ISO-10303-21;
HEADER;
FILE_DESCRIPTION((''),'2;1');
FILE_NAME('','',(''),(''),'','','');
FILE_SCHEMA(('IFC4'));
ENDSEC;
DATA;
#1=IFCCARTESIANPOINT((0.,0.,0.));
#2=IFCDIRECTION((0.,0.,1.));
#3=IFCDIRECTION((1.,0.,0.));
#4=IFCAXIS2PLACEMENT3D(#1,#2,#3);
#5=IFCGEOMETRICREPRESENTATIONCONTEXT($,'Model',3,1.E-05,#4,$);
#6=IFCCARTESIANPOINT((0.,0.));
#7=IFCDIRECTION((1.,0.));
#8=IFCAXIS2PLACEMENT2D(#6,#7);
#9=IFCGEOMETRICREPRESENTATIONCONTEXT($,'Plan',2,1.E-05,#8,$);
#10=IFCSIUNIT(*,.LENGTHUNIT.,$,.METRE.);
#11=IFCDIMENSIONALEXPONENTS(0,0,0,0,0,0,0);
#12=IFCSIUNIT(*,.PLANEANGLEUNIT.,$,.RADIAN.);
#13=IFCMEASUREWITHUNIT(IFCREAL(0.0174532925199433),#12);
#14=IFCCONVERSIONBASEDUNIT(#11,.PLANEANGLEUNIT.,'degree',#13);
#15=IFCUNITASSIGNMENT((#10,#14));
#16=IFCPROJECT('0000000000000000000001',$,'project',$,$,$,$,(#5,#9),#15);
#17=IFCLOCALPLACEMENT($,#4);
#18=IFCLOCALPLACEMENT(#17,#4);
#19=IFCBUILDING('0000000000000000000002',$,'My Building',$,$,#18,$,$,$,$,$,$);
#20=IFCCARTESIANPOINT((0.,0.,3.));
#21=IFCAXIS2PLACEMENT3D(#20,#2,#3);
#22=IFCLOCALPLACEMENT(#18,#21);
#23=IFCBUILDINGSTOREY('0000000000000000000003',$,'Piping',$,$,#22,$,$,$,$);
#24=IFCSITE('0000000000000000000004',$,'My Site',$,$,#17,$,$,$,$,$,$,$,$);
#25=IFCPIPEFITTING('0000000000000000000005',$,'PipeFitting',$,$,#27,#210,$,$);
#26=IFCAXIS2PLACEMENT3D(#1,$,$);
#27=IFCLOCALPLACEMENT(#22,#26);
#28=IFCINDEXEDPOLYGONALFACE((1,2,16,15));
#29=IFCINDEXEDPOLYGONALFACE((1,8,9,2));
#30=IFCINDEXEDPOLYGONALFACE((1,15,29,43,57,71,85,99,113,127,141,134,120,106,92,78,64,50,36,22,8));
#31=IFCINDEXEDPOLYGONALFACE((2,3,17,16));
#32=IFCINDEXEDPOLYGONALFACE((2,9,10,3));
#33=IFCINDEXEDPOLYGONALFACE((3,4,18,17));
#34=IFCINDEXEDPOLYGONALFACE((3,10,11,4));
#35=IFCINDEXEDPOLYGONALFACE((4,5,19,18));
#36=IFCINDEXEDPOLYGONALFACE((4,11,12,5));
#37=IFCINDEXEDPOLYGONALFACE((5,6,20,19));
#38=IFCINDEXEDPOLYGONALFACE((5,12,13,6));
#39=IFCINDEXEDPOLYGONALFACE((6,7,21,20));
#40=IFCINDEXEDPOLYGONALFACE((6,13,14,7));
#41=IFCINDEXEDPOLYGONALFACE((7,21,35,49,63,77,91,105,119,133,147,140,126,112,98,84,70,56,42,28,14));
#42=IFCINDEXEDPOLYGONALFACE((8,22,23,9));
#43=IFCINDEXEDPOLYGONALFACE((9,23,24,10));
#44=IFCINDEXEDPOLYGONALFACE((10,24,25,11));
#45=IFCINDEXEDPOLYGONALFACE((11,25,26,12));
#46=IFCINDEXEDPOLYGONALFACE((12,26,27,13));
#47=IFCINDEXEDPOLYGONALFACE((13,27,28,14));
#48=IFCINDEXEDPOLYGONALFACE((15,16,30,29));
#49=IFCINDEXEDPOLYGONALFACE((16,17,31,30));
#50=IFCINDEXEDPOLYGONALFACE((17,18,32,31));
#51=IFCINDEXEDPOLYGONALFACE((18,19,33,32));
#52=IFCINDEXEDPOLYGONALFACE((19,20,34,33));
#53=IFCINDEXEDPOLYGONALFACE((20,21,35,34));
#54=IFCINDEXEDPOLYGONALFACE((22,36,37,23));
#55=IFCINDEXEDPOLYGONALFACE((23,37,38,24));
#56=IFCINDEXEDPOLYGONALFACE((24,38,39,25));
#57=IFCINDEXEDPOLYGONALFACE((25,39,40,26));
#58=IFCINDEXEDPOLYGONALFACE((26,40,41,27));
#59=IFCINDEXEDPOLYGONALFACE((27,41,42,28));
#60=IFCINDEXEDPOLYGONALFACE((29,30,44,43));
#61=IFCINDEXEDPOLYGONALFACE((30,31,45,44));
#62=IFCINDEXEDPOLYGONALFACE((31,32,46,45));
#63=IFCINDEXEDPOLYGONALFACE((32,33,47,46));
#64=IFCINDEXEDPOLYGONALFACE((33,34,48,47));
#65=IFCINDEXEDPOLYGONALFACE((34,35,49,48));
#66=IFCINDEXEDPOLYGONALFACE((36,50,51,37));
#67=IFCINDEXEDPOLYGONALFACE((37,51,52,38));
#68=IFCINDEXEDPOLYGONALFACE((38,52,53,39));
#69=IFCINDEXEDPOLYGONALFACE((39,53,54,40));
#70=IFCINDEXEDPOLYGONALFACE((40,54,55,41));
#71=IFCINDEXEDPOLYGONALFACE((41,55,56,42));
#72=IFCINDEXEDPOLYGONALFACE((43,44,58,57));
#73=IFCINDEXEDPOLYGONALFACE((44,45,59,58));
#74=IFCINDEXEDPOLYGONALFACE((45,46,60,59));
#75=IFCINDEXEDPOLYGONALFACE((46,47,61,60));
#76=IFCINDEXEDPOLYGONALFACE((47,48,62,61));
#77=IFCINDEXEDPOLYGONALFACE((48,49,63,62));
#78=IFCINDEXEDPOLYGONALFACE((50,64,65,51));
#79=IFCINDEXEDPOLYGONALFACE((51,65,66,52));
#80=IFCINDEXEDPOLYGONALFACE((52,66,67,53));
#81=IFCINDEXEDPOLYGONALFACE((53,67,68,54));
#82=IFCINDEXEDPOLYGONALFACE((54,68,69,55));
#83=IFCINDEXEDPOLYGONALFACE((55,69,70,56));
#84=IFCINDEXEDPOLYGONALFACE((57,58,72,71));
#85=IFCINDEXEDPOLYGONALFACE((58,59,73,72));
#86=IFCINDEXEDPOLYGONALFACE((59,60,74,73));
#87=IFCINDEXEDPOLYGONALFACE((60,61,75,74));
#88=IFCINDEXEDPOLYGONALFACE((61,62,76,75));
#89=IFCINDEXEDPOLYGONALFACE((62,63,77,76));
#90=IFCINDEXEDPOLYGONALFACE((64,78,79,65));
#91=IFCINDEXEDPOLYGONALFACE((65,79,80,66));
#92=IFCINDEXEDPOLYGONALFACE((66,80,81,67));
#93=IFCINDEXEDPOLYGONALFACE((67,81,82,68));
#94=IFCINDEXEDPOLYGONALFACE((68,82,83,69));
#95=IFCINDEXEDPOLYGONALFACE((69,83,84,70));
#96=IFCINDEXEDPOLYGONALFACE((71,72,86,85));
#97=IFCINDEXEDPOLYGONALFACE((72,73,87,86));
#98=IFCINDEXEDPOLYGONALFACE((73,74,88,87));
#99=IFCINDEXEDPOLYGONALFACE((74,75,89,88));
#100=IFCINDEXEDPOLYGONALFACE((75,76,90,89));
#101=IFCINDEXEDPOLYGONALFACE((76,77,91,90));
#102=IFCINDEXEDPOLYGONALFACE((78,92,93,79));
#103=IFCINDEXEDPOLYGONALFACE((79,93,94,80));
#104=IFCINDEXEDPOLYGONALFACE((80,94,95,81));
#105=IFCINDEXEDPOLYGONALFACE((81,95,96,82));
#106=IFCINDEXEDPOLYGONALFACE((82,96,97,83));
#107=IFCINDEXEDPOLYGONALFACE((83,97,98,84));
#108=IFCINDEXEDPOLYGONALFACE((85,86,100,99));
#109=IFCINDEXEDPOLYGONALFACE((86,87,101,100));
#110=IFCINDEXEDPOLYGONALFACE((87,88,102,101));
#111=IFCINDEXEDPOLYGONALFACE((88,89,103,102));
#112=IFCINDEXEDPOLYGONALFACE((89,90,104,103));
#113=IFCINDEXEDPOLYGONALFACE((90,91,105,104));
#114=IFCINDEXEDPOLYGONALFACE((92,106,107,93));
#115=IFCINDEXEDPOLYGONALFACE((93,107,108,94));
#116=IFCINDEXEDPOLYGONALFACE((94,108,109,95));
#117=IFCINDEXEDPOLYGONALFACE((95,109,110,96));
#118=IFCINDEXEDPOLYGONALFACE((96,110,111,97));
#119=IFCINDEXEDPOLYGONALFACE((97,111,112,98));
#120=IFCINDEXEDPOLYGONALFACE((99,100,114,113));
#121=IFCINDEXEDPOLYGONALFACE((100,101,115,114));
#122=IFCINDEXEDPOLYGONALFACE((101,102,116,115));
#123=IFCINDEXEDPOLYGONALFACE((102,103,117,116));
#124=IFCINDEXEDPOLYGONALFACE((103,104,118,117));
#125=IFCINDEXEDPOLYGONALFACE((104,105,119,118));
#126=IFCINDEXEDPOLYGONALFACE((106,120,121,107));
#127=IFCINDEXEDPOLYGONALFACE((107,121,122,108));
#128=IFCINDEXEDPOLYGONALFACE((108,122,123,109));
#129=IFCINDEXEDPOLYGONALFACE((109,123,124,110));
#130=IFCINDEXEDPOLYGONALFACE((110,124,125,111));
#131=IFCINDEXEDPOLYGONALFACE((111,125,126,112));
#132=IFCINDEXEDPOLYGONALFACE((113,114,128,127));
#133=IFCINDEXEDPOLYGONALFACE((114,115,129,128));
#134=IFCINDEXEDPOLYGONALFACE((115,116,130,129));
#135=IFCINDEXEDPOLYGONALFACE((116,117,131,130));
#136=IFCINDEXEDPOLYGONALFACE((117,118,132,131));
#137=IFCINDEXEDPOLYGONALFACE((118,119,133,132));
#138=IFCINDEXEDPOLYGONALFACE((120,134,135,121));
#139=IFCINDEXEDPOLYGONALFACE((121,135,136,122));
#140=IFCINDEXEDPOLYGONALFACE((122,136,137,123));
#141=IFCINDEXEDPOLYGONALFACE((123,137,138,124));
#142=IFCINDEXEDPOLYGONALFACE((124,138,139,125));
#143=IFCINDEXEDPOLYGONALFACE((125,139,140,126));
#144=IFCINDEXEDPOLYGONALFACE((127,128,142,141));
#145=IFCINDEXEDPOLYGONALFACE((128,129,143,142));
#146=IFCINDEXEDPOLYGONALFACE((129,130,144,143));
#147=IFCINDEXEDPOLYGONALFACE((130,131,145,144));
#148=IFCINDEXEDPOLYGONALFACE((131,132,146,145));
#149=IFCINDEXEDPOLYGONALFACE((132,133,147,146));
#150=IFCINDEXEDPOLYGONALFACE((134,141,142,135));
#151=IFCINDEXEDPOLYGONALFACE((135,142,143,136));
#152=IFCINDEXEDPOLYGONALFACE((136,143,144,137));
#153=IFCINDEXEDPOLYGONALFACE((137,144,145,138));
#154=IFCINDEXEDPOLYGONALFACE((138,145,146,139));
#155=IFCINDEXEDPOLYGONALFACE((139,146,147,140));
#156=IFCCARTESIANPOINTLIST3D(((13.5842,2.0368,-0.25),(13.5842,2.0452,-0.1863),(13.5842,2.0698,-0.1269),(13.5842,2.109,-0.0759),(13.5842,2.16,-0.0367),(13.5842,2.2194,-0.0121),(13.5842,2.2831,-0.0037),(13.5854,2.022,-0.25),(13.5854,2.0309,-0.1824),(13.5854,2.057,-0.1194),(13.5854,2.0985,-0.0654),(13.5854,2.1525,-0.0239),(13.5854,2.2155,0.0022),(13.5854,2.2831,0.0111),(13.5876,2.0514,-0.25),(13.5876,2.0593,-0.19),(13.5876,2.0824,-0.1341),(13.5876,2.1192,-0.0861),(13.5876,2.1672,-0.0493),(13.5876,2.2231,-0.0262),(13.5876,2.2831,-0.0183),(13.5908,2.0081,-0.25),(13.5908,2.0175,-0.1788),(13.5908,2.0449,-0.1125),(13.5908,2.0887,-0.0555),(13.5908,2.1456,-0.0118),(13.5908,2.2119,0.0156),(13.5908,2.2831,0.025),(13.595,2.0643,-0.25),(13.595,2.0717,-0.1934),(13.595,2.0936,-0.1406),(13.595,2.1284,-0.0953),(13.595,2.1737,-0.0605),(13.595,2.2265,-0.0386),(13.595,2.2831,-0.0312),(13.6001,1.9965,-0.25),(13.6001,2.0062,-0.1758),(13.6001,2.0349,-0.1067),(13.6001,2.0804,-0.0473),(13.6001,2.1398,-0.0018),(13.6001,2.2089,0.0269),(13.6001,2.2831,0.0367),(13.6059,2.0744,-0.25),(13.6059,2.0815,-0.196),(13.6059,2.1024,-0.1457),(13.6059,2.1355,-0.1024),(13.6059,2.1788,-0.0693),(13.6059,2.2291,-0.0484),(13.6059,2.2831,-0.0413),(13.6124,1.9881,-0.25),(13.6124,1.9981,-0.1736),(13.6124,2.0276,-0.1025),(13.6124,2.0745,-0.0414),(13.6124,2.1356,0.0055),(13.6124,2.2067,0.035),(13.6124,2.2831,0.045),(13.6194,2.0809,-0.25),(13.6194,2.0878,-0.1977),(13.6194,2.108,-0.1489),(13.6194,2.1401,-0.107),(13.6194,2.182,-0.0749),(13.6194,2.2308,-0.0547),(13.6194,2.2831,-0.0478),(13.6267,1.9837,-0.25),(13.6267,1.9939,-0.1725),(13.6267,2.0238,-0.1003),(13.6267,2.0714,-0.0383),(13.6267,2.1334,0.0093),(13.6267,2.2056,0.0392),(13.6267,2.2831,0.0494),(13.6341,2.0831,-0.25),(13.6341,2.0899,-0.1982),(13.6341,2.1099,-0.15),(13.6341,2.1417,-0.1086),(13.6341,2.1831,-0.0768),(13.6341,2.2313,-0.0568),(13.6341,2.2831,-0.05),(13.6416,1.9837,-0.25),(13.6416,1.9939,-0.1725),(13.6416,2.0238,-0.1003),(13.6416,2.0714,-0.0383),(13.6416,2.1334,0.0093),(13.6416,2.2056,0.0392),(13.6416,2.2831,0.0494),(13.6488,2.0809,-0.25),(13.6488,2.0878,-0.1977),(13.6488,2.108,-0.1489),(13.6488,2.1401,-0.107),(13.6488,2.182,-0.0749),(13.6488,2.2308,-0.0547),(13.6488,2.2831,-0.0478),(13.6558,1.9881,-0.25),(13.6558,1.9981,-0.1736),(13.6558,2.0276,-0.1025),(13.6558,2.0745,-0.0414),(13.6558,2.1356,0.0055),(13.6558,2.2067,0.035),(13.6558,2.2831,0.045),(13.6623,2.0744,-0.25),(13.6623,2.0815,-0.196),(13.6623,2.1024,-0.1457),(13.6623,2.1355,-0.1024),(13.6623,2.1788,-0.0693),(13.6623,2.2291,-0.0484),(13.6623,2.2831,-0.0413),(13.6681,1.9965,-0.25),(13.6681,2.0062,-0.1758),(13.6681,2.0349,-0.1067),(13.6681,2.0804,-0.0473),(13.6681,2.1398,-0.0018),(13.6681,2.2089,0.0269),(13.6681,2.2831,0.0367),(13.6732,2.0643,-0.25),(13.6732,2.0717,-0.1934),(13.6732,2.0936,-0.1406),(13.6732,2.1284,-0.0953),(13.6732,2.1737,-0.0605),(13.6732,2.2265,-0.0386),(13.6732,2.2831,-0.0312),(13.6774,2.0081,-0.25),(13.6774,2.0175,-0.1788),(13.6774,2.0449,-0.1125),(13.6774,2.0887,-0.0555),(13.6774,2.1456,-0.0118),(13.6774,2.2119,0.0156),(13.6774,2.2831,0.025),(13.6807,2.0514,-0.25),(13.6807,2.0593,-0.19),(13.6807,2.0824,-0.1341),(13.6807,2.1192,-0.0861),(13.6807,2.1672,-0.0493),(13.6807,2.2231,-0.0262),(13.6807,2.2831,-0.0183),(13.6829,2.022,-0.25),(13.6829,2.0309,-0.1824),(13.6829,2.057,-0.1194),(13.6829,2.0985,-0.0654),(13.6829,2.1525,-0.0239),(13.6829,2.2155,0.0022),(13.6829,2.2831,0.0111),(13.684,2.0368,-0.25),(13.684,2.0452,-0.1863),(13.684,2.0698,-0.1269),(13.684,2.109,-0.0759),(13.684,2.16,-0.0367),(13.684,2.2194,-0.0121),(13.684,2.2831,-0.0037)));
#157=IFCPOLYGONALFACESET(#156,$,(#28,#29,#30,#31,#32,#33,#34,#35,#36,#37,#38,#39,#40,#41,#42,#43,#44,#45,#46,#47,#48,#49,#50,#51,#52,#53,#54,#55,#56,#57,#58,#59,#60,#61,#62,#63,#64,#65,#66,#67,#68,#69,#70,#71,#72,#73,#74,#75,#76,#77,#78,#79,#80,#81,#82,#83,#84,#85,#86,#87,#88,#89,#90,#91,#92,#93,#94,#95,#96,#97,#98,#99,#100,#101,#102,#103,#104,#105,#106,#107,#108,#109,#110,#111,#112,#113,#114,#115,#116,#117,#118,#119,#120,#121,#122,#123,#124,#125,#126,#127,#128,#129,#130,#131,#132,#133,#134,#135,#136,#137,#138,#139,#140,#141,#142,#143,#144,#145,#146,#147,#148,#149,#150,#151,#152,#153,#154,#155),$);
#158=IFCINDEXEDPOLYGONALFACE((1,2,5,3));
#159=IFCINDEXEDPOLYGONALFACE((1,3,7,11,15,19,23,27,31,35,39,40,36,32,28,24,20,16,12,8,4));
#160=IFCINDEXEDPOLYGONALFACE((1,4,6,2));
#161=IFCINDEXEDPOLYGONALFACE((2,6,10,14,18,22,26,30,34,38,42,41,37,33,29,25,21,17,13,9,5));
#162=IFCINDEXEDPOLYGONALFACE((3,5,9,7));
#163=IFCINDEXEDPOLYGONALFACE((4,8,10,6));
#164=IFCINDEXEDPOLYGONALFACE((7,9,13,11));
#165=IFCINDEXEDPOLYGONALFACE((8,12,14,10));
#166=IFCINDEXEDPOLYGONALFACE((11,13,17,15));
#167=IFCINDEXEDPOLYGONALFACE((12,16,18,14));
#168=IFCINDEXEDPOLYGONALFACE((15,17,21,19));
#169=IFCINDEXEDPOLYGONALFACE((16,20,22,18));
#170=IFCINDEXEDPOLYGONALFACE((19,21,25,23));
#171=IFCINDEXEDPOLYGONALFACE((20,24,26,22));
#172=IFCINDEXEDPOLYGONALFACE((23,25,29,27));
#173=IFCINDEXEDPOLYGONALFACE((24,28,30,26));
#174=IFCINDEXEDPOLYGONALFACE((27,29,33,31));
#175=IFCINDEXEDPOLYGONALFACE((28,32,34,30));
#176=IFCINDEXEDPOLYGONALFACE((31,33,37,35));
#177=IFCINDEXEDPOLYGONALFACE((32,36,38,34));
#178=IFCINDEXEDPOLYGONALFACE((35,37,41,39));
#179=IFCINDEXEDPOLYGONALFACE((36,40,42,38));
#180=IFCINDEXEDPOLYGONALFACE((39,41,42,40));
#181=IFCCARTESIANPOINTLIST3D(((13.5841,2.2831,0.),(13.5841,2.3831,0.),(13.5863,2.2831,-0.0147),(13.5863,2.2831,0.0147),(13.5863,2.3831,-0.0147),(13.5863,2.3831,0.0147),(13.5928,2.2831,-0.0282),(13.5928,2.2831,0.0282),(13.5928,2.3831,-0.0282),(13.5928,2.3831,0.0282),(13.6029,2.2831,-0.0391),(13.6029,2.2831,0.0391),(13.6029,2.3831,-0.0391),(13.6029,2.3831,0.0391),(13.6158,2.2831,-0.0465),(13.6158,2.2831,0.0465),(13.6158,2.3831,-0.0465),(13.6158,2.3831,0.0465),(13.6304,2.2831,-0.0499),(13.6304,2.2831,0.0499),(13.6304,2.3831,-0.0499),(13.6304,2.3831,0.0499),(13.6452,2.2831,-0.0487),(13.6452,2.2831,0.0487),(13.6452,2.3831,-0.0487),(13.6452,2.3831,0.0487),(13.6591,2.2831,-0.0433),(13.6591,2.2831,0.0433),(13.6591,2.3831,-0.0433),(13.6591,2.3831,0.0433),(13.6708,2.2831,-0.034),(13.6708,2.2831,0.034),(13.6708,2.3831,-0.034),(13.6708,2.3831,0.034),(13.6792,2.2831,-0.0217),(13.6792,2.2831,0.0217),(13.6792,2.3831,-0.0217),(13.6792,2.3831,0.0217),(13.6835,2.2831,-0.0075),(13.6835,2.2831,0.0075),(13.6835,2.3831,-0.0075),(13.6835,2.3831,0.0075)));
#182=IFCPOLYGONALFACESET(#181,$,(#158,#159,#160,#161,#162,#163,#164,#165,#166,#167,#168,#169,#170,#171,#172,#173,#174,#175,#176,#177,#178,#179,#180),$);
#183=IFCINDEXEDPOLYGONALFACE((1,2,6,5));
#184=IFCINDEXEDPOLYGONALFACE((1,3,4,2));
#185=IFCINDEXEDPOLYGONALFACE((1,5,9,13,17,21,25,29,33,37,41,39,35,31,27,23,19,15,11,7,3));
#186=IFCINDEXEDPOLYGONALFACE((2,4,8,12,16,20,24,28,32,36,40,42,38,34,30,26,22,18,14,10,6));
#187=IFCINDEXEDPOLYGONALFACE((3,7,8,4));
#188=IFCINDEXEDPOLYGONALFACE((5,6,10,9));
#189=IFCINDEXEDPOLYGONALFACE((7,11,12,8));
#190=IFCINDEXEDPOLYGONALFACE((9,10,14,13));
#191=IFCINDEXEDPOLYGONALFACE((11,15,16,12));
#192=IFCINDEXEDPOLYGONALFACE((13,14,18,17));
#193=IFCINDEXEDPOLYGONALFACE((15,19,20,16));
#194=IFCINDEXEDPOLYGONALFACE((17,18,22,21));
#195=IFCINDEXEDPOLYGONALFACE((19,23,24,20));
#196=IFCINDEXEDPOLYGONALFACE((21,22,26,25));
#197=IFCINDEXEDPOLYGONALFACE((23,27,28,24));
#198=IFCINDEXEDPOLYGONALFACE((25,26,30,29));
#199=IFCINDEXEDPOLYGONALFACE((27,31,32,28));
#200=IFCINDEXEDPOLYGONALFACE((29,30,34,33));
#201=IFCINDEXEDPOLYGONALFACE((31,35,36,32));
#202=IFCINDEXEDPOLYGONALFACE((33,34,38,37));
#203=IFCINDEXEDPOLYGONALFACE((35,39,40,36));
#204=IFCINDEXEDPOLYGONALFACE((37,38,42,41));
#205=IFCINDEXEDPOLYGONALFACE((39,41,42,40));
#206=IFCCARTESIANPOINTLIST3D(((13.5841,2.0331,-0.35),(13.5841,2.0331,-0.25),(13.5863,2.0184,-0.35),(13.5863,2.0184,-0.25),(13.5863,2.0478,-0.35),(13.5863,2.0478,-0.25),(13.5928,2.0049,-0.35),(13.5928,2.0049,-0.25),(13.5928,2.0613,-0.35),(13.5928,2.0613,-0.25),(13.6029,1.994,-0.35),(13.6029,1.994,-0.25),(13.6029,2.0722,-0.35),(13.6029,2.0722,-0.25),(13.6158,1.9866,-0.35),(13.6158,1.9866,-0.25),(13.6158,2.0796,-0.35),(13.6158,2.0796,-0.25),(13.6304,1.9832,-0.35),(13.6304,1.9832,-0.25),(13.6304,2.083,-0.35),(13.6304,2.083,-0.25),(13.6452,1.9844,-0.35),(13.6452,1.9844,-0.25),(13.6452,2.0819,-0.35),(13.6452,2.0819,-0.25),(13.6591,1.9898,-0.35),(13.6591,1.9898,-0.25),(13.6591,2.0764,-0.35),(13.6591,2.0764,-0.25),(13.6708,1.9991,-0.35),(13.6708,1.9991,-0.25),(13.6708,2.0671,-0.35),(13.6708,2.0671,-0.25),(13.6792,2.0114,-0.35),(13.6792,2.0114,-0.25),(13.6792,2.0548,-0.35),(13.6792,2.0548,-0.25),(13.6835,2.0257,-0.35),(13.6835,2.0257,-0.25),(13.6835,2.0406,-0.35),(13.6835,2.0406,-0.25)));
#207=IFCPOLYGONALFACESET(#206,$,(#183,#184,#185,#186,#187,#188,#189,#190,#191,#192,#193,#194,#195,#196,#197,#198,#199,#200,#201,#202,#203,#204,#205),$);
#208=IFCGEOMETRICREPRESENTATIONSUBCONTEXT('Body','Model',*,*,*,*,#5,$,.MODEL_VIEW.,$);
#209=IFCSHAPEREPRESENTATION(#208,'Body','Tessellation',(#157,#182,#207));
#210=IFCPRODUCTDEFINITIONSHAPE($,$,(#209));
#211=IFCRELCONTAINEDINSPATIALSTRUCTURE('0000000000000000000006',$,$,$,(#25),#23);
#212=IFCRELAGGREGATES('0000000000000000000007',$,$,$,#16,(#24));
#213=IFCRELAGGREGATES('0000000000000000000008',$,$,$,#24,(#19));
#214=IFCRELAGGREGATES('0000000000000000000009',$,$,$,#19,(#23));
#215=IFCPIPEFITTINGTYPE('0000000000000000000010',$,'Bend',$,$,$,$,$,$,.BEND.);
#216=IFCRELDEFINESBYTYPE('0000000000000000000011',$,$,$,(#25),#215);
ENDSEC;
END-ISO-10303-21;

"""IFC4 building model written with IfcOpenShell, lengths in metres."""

from ifc_helpers import new_model, entity, si_unit, converted_unit, frame, origin_with_axes, origin_2d_with_axis, place, context, subcontext, project, spatial, circle, extrude, source, transform, mapped, type_object, type_shapes, element, save


model = new_model("IFC4")

# Units and contexts
model_context = context("Model", 3, precision=1e-05, world=origin_with_axes())
plan_context = context("Plan", 2, precision=1e-05, world=origin_2d_with_axis())
body_context = subcontext(model_context, "Body", "Model", "MODEL_VIEW")
ifc_project = project(units=[si_unit("LENGTHUNIT", "METRE"), converted_unit("PLANEANGLEUNIT", "degree", entity("IfcReal", 0.0174532925199433), si_unit("PLANEANGLEUNIT", "RADIAN"), dimensions=[0, 0, 0, 0, 0, 0, 0])], contexts=[model_context, plan_context])

# Site, building, storey
site_placement = place(None, origin_with_axes())
site = spatial("IfcSite", under=ifc_project, at=site_placement, Name="My Site")
building_placement = place(site_placement, origin_with_axes())
building = spatial("IfcBuilding", under=site, at=building_placement, Name="My Building")
storey_placement = place(building_placement, frame((0.0, 0.0, 3.0), z_axis=(0.0, 0.0, 1.0), x_axis=(1.0, 0.0, 0.0)))
storey = spatial("IfcBuildingStorey", under=building, at=storey_placement, Name="Piping")

# Pipe fitting
pipe_fitting_type = type_object("IfcPipeFittingType", Name="Bend", PredefinedType="BEND")
shared_shape = source(origin_with_axes(), body_context, "Body", "SolidModel", [
    entity("IfcSweptDiskSolid", entity("IfcIndexedPolyCurve", entity("IfcCartesianPointList3D", [[0.0, 0.0, -0.1], [0.0, -0.0732, -0.2768], [0.0, -0.25, -0.35]]), [entity("IfcArcIndex", [1, 2, 3])]), 0.05),
    extrude(circle(Radius=0.05), origin_with_axes(), (0.0, 0.0, -1.0), 0.1),
    extrude(circle(Radius=0.05), frame((0.0, -0.25, -0.35), z_axis=(0.0, -1.0, 0.0), x_axis=(1.0, 0.0, 0.0)), (0.0, 0.0, 1.0), 0.1),
])
type_shapes(pipe_fitting_type, [shared_shape])
for number, where, z_axis, x_axis, name in (
    (1, (13.6341, 2.3831, 0.0), (0.0, 1.0, 0.0), (-1.0, 0.0, 0.0), "PipeFitting"),
):
    element("IfcPipeFitting", number, at=place(storey_placement, frame(where, z_axis=z_axis, x_axis=x_axis)), inside=storey, type_object=pipe_fitting_type, Name=name, context=body_context, shape_type="MappedRepresentation", body=[
        mapped(shared_shape, transform((0.0, 0.0, 0.0), x_axis=(1.0, 0.0, 0.0), y_axis=(0.0, 1.0, 0.0), z_axis=(0.0, 0.0, 1.0), scale=1.0)),
    ])

save(model, "model.ifc")
